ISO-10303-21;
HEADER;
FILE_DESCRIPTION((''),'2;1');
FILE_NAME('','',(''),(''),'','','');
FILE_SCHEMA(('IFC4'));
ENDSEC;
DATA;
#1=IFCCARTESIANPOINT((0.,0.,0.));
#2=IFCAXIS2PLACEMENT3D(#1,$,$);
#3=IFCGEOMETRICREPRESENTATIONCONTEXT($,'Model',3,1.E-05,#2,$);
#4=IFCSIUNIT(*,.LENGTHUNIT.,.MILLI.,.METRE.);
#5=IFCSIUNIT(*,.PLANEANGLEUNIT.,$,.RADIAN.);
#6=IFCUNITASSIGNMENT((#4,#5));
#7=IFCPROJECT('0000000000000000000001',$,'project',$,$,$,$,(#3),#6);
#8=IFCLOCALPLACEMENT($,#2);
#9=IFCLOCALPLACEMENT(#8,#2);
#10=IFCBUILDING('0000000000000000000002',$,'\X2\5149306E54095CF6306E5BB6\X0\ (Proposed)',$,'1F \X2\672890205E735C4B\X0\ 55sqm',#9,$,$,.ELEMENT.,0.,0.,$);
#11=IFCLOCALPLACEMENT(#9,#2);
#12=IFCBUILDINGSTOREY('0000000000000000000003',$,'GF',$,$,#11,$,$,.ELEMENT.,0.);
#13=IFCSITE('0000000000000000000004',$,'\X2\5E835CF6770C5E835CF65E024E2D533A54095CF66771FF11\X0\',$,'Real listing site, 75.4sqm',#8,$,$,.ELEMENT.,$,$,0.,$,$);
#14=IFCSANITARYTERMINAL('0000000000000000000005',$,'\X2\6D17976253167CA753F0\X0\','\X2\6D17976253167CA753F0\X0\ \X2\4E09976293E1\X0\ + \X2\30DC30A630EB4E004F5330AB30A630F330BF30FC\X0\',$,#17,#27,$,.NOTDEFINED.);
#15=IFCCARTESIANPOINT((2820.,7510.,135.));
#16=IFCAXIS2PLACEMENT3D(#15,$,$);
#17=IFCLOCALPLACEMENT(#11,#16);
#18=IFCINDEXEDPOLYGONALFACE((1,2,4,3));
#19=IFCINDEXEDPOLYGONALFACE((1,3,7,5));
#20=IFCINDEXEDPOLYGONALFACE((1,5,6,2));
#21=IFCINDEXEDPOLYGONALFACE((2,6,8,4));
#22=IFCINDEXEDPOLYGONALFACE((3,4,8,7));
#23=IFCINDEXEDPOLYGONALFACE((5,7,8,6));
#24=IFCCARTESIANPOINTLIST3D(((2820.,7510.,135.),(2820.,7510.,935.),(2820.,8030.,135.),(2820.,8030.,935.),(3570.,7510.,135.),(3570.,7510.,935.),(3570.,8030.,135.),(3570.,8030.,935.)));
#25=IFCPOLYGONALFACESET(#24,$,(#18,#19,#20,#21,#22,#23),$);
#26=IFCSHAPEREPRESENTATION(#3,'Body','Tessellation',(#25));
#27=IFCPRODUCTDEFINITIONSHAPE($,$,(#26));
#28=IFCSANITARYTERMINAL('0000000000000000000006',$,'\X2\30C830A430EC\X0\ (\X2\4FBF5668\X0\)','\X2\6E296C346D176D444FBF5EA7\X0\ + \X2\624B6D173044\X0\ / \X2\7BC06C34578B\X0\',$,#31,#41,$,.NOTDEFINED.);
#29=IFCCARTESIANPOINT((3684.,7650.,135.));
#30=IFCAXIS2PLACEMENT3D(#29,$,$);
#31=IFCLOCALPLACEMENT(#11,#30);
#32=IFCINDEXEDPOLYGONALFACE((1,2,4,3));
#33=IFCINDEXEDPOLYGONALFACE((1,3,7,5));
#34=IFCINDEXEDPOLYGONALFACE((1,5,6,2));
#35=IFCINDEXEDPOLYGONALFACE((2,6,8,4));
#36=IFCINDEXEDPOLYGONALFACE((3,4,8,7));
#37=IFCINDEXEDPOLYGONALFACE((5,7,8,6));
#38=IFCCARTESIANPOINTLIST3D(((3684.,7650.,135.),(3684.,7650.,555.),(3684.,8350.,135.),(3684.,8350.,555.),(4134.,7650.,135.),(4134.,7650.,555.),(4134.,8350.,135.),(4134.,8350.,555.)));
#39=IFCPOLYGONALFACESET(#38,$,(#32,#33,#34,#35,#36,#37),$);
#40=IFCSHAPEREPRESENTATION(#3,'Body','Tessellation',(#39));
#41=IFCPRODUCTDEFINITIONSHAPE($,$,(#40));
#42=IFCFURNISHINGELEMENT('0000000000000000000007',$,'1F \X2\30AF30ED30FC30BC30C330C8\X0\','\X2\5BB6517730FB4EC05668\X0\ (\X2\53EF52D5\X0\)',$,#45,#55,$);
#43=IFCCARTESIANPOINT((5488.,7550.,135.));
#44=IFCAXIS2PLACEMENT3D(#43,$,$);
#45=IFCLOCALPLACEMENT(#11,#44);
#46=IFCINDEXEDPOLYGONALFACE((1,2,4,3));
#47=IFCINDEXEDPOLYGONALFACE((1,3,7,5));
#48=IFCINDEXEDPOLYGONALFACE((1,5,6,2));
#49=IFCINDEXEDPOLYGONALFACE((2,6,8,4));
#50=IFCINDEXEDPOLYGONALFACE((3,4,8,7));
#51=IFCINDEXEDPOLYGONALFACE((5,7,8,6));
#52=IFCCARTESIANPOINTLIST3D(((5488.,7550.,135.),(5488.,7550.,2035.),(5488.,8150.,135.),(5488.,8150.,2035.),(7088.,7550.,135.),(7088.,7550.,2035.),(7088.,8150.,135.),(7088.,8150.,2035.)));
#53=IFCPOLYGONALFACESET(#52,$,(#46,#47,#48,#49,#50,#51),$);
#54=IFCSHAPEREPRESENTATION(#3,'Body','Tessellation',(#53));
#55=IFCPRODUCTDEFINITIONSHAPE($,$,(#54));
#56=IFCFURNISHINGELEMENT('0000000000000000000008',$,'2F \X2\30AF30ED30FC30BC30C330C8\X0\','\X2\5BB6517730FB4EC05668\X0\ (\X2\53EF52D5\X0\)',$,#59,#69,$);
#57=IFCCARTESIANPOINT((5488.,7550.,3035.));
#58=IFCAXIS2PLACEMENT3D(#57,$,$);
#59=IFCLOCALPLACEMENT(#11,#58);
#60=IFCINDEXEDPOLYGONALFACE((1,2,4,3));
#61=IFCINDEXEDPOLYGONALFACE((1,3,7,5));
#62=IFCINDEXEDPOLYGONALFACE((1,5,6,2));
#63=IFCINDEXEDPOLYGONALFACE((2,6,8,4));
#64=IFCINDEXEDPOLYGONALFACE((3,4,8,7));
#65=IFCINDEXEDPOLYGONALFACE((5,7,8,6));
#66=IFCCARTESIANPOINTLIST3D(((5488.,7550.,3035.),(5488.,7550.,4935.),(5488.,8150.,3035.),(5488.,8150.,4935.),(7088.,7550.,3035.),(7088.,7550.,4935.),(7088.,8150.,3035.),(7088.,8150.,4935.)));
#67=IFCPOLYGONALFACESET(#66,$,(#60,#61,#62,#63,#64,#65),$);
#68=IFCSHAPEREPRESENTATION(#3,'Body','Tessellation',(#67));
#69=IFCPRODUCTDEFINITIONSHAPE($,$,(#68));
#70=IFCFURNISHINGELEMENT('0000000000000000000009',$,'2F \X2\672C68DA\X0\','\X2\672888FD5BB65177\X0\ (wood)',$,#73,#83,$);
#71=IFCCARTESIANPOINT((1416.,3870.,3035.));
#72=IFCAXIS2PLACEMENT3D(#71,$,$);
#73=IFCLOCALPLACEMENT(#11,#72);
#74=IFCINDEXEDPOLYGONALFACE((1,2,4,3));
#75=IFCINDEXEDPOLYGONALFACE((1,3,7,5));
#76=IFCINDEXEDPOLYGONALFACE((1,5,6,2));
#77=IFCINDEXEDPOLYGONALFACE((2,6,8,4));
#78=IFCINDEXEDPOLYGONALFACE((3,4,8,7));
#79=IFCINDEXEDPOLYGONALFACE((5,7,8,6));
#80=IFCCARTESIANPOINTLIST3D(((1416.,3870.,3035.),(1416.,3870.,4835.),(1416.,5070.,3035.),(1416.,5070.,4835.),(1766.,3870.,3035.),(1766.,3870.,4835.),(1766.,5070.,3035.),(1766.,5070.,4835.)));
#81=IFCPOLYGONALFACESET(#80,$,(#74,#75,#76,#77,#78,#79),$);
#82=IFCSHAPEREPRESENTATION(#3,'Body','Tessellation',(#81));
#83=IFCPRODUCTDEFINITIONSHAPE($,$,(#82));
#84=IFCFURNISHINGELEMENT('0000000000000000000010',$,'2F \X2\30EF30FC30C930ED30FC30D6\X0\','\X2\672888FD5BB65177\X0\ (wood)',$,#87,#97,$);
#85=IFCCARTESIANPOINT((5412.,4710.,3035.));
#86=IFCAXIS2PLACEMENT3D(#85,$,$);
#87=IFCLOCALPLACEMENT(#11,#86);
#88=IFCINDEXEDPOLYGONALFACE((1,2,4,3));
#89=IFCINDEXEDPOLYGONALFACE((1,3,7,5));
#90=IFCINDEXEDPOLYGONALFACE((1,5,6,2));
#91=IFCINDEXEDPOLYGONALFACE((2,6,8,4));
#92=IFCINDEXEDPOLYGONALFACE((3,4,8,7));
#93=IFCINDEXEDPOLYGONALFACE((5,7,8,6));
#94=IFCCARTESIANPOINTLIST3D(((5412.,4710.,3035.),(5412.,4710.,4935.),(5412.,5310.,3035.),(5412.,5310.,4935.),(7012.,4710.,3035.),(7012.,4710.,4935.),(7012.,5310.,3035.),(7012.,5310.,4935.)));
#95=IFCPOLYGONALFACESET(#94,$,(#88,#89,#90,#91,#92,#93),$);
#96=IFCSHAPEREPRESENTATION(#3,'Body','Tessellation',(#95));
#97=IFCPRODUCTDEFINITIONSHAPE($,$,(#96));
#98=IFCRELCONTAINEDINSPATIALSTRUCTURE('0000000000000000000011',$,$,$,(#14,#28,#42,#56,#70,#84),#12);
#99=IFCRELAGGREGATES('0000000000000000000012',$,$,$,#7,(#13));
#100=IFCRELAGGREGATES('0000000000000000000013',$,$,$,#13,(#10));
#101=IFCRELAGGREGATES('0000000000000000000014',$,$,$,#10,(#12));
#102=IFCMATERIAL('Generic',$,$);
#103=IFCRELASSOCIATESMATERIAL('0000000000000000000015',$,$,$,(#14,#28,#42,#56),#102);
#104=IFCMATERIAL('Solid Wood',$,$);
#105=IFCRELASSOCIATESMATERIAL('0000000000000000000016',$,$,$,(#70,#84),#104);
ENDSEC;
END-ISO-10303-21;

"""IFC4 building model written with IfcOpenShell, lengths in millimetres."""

from ifc_helpers import new_model, si_unit, frame, frame_2d, origin, place, context, project, spatial, rectangle, extrude, material, element, save


model = new_model("IFC4")

# Units and contexts
model_context = context("Model", 3, precision=1e-05, world=origin())
ifc_project = project(units=[si_unit("LENGTHUNIT", "METRE", prefix="MILLI"), si_unit("PLANEANGLEUNIT", "RADIAN")], contexts=[model_context])

# Site, building, storey
site_placement = place(None, origin())
site = spatial("IfcSite", under=ifc_project, at=site_placement, Name="広島県広島市中区吉島東１", ObjectType="Real listing site, 75.4sqm", CompositionType="ELEMENT", RefElevation=0.0)
building_placement = place(site_placement, origin())
building = spatial("IfcBuilding", under=site, at=building_placement, Name="光の吉島の家 (Proposed)", ObjectType="1F 木造平屋 55sqm", CompositionType="ELEMENT", ElevationOfRefHeight=0.0, ElevationOfTerrain=0.0)
storey_placement = place(building_placement, origin())
storey = spatial("IfcBuildingStorey", under=building, at=storey_placement, Name="GF", CompositionType="ELEMENT", Elevation=0.0)

# Shared definitions
ifc_material_1 = material(Name="Solid Wood")

# Shared definitions
ifc_material_2 = material(Name="Generic")

# Sanitary terminals
sanitary_terminal_1_placement = place(storey_placement, frame((2820.0, 7510.0, 135.0)))
element("IfcSanitaryTerminal", 1, at=sanitary_terminal_1_placement, inside=storey, material=ifc_material_2, Name="洗面化粧台", Description="洗面化粧台 三面鏡 + ボウル一体カウンター", PredefinedType="NOTDEFINED", context=model_context, shape_type="SweptSolid", body=[
    extrude(rectangle(XDim=750.0, YDim=520.0, at=frame_2d((375.0, 260.0))), frame((2820.0, 7510.0, 135.0)), (0.0, 0.0, 1.0), 800.0),
])
sanitary_terminal_2_placement = place(storey_placement, frame((3684.0, 7650.0, 135.0)))
element("IfcSanitaryTerminal", 2, at=sanitary_terminal_2_placement, inside=storey, material=ifc_material_2, Name="トイレ (便器)", Description="温水洗浄便座 + 手洗い / 節水型", PredefinedType="NOTDEFINED", context=model_context, shape_type="SweptSolid", body=[
    extrude(rectangle(XDim=450.0, YDim=700.0, at=frame_2d((225.0, 350.0))), frame((3684.0, 7650.0, 135.0)), (0.0, 0.0, 1.0), 420.0),
])

# Furnishing elements
furnishing_1_placement = place(storey_placement, frame((5488.0, 7550.0, 135.0)))
element("IfcFurnishingElement", 3, at=furnishing_1_placement, inside=storey, material=ifc_material_2, Name="1F クローゼット", Description="家具・什器 (可動)", context=model_context, shape_type="SweptSolid", body=[
    extrude(rectangle(XDim=1600.0, YDim=600.0, at=frame_2d((800.0, 300.0))), frame((5488.0, 7550.0, 135.0)), (0.0, 0.0, 1.0), 1900.0),
])
furnishing_2_placement = place(storey_placement, frame((5488.0, 7550.0, 3035.0)))
element("IfcFurnishingElement", 4, at=furnishing_2_placement, inside=storey, material=ifc_material_2, Name="2F クローゼット", Description="家具・什器 (可動)", context=model_context, shape_type="SweptSolid", body=[
    extrude(rectangle(XDim=1600.0, YDim=600.0, at=frame_2d((800.0, 300.0))), frame((5488.0, 7550.0, 3035.0)), (0.0, 0.0, 1.0), 1900.0),
])
furnishing_3_placement = place(storey_placement, frame((1416.0, 3870.0, 3035.0)))
element("IfcFurnishingElement", 5, at=furnishing_3_placement, inside=storey, material=ifc_material_1, Name="2F 本棚", Description="木製家具 (wood)", context=model_context, shape_type="SweptSolid", body=[
    extrude(rectangle(XDim=350.0, YDim=1200.0, at=frame_2d((175.0, 600.0))), frame((1416.0, 3870.0, 3035.0)), (0.0, 0.0, 1.0), 1800.0),
])
furnishing_4_placement = place(storey_placement, frame((5412.0, 4710.0, 3035.0)))
element("IfcFurnishingElement", 6, at=furnishing_4_placement, inside=storey, material=ifc_material_1, Name="2F ワードローブ", Description="木製家具 (wood)", context=model_context, shape_type="SweptSolid", body=[
    extrude(rectangle(XDim=1600.0, YDim=600.0, at=frame_2d((800.0, 300.0))), frame((5412.0, 4710.0, 3035.0)), (0.0, 0.0, 1.0), 1900.0),
])

save(model, "model.ifc")
